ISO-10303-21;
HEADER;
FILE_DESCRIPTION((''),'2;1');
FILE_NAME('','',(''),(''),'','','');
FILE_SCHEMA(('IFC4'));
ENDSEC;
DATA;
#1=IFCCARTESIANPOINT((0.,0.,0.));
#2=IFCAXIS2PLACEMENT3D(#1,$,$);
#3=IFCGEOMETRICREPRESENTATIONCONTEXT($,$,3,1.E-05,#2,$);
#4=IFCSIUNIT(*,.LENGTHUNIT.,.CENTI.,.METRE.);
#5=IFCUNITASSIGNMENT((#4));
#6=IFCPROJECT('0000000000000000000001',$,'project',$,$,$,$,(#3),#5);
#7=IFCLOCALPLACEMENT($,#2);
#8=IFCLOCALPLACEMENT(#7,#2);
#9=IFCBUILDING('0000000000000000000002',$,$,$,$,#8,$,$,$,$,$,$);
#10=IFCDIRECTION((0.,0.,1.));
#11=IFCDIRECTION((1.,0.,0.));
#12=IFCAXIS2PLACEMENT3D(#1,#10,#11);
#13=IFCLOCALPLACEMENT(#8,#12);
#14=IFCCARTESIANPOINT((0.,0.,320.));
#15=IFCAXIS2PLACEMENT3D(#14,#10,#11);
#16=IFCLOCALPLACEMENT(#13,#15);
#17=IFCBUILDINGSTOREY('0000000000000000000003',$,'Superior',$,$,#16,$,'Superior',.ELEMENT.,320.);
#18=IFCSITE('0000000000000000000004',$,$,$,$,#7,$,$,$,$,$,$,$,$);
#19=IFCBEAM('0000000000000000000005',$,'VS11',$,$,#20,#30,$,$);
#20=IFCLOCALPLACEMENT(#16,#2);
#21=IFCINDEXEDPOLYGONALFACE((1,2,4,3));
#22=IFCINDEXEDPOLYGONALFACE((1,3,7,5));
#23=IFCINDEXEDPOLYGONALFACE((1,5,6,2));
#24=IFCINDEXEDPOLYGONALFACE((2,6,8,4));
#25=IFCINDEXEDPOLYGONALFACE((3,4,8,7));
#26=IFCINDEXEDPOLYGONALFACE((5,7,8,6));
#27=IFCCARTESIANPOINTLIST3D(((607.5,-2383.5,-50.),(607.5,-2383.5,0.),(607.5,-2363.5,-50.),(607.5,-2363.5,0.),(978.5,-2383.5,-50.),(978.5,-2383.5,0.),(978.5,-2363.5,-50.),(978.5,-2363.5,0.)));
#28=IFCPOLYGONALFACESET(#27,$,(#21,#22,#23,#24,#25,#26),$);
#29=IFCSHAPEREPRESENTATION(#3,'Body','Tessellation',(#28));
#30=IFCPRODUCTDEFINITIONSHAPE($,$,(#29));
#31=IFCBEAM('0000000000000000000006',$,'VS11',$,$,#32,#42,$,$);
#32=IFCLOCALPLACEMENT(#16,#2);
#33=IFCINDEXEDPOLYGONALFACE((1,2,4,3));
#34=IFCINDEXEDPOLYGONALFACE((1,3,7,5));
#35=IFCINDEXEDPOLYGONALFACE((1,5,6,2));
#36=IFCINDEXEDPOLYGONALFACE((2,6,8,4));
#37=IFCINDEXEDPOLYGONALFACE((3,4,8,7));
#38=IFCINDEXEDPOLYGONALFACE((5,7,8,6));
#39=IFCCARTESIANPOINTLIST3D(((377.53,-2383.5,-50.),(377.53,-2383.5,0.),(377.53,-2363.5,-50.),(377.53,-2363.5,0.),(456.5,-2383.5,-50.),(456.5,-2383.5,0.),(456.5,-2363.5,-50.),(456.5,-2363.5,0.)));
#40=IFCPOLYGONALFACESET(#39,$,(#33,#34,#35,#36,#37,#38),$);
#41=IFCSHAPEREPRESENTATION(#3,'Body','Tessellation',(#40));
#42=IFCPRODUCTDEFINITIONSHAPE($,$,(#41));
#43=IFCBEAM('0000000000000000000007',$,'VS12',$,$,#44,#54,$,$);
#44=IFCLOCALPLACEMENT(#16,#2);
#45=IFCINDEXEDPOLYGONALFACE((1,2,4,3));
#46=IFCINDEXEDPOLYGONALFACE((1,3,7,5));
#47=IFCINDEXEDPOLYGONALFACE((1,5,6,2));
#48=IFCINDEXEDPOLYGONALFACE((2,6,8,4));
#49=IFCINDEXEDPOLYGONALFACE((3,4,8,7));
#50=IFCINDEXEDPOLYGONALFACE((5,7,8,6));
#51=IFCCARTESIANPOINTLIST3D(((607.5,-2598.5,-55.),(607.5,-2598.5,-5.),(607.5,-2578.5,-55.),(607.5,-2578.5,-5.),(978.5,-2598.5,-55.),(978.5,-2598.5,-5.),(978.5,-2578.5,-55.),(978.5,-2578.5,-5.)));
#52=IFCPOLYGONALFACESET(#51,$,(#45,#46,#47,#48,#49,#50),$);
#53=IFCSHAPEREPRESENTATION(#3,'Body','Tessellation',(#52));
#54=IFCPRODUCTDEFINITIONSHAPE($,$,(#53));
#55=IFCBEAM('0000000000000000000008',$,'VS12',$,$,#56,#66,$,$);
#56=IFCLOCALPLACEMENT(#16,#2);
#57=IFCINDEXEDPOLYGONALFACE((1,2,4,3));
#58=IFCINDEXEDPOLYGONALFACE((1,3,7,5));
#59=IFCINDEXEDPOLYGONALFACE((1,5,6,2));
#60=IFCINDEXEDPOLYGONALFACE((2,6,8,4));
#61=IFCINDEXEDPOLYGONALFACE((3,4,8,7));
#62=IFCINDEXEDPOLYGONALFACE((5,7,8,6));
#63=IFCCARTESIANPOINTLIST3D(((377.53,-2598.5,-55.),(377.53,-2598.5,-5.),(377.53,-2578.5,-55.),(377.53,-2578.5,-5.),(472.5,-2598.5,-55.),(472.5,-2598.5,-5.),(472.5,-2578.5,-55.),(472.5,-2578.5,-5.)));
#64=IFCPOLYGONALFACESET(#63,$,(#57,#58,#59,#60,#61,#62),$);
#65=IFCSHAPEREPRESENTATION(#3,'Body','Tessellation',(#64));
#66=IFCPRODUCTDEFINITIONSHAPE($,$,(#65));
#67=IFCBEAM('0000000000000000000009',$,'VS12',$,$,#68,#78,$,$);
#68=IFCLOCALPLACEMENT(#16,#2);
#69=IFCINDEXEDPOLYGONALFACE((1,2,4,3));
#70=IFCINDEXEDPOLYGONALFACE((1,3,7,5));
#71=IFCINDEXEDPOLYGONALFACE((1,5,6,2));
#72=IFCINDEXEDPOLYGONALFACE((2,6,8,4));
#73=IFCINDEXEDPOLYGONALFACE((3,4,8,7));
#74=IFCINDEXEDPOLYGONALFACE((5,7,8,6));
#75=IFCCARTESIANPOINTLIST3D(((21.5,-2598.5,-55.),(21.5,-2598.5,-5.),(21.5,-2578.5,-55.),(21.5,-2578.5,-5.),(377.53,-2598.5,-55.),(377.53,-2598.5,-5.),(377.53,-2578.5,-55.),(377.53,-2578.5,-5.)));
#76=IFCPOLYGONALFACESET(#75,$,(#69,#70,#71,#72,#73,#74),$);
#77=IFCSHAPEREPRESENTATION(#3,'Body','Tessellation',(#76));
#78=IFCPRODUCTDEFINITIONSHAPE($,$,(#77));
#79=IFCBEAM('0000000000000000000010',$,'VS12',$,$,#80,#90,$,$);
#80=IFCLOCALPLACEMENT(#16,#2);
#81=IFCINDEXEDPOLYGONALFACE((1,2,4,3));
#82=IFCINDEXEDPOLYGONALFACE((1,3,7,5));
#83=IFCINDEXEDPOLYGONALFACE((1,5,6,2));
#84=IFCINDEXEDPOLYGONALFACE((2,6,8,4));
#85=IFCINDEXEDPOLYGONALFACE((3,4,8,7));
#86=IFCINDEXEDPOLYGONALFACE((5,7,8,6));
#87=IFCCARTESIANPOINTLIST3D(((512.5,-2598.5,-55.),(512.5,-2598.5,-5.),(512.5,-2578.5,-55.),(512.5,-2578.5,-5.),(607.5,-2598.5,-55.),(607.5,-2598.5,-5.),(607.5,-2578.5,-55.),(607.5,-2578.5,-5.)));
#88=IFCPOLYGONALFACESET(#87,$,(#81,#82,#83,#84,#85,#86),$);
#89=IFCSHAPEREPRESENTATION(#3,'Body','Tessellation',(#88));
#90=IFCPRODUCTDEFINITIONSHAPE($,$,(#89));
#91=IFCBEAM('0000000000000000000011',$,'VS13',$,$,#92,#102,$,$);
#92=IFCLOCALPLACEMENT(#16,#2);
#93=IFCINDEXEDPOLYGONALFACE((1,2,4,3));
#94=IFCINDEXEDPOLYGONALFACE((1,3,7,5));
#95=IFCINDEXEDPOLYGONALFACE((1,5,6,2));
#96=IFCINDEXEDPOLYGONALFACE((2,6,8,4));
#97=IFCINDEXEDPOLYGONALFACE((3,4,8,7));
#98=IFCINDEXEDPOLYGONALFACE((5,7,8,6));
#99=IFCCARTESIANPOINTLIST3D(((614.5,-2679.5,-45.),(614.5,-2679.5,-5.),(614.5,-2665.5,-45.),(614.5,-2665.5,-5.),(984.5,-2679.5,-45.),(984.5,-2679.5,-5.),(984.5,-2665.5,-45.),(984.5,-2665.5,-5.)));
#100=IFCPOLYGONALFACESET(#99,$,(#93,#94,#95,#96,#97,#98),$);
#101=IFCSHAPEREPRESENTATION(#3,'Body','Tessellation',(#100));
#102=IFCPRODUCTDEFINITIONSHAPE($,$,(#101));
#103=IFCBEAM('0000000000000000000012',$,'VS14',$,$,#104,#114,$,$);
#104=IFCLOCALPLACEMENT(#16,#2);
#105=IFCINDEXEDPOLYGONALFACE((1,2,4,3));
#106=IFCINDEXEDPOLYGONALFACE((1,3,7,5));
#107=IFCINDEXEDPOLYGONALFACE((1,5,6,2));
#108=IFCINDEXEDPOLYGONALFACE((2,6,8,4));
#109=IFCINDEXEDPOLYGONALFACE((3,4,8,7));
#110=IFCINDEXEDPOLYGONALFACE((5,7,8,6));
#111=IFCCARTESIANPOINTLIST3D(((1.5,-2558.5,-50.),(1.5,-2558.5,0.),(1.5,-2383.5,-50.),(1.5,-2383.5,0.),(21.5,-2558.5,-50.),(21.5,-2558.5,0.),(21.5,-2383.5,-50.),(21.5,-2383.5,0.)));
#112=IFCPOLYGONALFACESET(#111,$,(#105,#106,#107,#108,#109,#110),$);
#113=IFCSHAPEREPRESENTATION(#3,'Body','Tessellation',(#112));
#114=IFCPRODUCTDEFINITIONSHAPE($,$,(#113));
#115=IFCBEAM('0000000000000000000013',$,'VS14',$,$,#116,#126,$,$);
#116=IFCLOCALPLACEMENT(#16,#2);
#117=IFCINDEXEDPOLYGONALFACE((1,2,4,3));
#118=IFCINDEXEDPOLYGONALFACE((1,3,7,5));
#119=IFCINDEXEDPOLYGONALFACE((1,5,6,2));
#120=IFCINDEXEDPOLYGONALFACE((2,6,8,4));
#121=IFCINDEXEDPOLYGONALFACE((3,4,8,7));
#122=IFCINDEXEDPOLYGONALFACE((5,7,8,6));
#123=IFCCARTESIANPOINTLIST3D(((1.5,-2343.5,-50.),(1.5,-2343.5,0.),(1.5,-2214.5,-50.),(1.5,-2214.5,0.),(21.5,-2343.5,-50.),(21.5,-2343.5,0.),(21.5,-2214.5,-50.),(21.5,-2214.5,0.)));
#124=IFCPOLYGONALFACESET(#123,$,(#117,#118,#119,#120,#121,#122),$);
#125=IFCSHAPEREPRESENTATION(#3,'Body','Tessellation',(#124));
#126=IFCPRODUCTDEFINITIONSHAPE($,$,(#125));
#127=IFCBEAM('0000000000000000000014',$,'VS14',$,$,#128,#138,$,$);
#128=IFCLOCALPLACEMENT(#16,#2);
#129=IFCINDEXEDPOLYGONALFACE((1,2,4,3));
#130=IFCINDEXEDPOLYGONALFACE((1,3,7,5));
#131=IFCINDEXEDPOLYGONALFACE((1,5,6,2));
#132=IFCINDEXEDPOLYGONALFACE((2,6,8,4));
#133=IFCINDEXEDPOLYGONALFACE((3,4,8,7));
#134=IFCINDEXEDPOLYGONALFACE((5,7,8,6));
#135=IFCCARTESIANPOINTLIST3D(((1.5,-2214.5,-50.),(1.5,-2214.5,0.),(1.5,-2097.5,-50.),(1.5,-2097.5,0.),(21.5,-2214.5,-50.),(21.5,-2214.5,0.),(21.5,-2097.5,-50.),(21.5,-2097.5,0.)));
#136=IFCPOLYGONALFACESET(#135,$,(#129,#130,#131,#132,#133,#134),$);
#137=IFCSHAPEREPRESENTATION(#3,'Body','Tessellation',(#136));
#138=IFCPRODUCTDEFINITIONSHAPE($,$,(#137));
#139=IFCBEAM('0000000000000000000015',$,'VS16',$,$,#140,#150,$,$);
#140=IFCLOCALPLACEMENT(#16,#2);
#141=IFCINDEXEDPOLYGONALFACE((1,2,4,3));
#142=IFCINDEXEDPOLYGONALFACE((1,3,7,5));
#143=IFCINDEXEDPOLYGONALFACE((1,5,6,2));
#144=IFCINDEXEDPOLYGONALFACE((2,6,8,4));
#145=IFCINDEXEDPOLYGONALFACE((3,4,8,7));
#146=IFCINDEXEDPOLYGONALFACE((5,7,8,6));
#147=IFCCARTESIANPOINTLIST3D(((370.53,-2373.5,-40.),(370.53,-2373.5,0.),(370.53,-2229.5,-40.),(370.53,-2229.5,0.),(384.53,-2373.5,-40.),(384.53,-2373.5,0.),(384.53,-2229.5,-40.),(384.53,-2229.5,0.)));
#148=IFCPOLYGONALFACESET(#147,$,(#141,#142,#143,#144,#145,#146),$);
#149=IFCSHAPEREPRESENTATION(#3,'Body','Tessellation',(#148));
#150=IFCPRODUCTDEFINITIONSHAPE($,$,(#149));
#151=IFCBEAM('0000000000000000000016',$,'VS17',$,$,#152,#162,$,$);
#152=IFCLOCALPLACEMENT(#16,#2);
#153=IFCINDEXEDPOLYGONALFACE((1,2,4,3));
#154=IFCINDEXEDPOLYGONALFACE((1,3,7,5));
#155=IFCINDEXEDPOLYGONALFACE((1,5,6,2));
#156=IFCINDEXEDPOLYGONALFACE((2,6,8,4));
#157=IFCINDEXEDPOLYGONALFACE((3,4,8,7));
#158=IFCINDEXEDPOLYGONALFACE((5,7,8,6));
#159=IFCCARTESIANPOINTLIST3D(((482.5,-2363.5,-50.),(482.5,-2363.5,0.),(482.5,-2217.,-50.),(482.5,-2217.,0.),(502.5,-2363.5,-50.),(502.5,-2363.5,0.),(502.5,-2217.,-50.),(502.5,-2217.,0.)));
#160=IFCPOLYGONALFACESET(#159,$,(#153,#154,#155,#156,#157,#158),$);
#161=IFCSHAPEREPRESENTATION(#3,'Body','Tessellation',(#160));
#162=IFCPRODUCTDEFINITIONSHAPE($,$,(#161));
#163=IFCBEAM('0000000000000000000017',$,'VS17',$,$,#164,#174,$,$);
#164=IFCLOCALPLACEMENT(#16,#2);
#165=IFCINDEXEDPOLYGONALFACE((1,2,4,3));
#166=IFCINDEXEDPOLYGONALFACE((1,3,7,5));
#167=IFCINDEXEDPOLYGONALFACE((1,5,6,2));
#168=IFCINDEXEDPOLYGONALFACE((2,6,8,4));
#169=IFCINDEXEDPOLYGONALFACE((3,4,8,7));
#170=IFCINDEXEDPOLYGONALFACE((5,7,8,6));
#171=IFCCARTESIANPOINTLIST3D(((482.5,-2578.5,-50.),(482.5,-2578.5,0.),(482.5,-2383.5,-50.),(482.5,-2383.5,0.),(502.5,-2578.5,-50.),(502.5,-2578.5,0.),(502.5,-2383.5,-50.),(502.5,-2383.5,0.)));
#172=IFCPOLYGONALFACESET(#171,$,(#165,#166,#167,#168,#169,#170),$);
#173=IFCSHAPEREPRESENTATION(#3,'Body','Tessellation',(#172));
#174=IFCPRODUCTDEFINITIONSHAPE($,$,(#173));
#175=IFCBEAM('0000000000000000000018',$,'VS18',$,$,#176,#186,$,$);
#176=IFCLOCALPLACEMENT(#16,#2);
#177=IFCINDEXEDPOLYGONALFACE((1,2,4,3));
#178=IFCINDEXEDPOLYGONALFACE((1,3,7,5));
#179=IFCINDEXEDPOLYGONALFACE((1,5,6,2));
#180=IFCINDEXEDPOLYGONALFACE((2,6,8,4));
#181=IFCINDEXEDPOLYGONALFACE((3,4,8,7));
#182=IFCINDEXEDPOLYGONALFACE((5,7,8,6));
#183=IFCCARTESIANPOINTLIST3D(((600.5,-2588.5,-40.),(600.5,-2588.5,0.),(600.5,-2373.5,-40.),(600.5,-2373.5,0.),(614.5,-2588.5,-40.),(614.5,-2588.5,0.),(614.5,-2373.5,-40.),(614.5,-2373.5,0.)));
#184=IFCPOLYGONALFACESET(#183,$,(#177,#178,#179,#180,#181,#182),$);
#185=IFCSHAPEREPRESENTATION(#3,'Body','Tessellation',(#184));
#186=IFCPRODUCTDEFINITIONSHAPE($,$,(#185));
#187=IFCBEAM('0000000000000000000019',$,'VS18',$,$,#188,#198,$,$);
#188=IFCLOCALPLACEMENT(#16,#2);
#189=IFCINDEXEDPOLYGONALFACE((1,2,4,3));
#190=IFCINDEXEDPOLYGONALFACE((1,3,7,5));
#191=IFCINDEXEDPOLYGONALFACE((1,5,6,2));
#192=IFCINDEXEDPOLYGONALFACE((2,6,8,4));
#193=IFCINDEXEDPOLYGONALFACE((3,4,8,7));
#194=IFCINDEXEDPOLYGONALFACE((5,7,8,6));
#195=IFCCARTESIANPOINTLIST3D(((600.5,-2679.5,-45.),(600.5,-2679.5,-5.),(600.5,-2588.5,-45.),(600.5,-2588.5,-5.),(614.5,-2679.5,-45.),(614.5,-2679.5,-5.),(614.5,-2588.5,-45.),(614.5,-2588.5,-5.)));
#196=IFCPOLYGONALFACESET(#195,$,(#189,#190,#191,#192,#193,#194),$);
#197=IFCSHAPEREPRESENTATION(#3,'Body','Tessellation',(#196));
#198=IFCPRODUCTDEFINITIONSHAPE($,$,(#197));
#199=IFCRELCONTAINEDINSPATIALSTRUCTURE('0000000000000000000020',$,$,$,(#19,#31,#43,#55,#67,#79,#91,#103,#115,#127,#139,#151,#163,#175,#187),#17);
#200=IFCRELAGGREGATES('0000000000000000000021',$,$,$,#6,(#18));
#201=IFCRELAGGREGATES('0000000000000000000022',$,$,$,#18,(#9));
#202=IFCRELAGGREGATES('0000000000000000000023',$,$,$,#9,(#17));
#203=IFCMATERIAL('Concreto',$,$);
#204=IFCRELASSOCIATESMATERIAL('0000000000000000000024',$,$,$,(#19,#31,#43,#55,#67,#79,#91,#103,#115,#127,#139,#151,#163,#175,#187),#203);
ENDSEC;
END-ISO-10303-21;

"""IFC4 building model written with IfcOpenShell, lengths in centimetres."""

from ifc_helpers import new_model, si_unit, frame, origin, origin_with_axes, place, context, project, spatial, polyline, outline, extrude, material, element, save


model = new_model("IFC4")

# Units and contexts
context_of_model = context(None, 3, precision=1e-05, world=origin())
ifc_project = project(units=[si_unit("LENGTHUNIT", "METRE", prefix="CENTI")], contexts=[context_of_model])

# Site, building, storey
site_placement = place(None, origin())
site = spatial("IfcSite", under=ifc_project, at=site_placement)
building_placement = place(site_placement, origin())
building = spatial("IfcBuilding", under=site, at=building_placement)
placement = place(building_placement, origin_with_axes())
storey_placement = place(placement, frame((0.0, 0.0, 320.0), z_axis=(0.0, 0.0, 1.0), x_axis=(1.0, 0.0, 0.0)))
storey = spatial("IfcBuildingStorey", under=building, at=storey_placement, Name="Superior", LongName="Superior", CompositionType="ELEMENT", Elevation=320.0)

# Shared definitions
ifc_material = material(Name="Concreto")

# Beams
beam_1_placement = place(storey_placement, frame((793.0, -2373.5, 0.0), z_axis=(0.0, 0.0, 1.0), x_axis=(1.0, 0.0, 0.0)))
element("IfcBeam", 1, at=beam_1_placement, inside=storey, material=ifc_material, Name="VS11", context=context_of_model, shape_type="SolidModel", body=[
    extrude(outline(polyline([(-10.0, -25.0), (10.0, -25.0), (10.0, 25.0), (-10.0, 25.0), (-10.0, -25.0)])), frame((-185.5, 0.0, -25.0), z_axis=(1.0, 0.0, 0.0), x_axis=(0.0, -1.0, 0.0)), (0.0, 0.0, 1.0), 371.0),
])
beam_2_placement = place(storey_placement, frame((417.01, -2373.5, 0.0), z_axis=(0.0, 0.0, 1.0), x_axis=(1.0, 0.0, 0.0)))
element("IfcBeam", 2, at=beam_2_placement, inside=storey, material=ifc_material, Name="VS11", context=context_of_model, shape_type="SolidModel", body=[
    extrude(outline(polyline([(-10.0, -25.0), (10.0, -25.0), (10.0, 25.0), (-10.0, 25.0), (-10.0, -25.0)])), frame((-39.48, 0.0, -25.0), z_axis=(1.0, 0.0, 0.0), x_axis=(0.0, -1.0, 0.0)), (0.0, 0.0, 1.0), 78.97),
])
beam_3_placement = place(storey_placement, frame((793.0, -2588.5, -5.0), z_axis=(0.0, 0.0, 1.0), x_axis=(1.0, 0.0, 0.0)))
element("IfcBeam", 3, at=beam_3_placement, inside=storey, material=ifc_material, Name="VS12", context=context_of_model, shape_type="SolidModel", body=[
    extrude(outline(polyline([(-10.0, -25.0), (10.0, -25.0), (10.0, 25.0), (-10.0, 25.0), (-10.0, -25.0)])), frame((-185.5, 0.0, -25.0), z_axis=(1.0, 0.0, 0.0), x_axis=(0.0, -1.0, 0.0)), (0.0, 0.0, 1.0), 371.0),
])
beam_4_placement = place(storey_placement, frame((425.01, -2588.5, -5.0), z_axis=(0.0, 0.0, 1.0), x_axis=(1.0, 0.0, 0.0)))
element("IfcBeam", 4, at=beam_4_placement, inside=storey, material=ifc_material, Name="VS12", context=context_of_model, shape_type="SolidModel", body=[
    extrude(outline(polyline([(-10.0, -25.0), (10.0, -25.0), (10.0, 25.0), (-10.0, 25.0), (-10.0, -25.0)])), frame((-47.48, 0.0, -25.0), z_axis=(1.0, 0.0, 0.0), x_axis=(0.0, -1.0, 0.0)), (0.0, 0.0, 1.0), 94.97),
])
beam_5_placement = place(storey_placement, frame((199.51, -2588.5, -5.0), z_axis=(0.0, 0.0, 1.0), x_axis=(1.0, 0.0, 0.0)))
element("IfcBeam", 5, at=beam_5_placement, inside=storey, material=ifc_material, Name="VS12", context=context_of_model, shape_type="SolidModel", body=[
    extrude(outline(polyline([(-10.0, -25.0), (10.0, -25.0), (10.0, 25.0), (-10.0, 25.0), (-10.0, -25.0)])), frame((-178.01, 0.0, -25.0), z_axis=(1.0, 0.0, 0.0), x_axis=(0.0, -1.0, 0.0)), (0.0, 0.0, 1.0), 356.03),
])
beam_6_placement = place(storey_placement, frame((560.0, -2588.5, -5.0), z_axis=(0.0, 0.0, 1.0), x_axis=(1.0, 0.0, 0.0)))
element("IfcBeam", 6, at=beam_6_placement, inside=storey, material=ifc_material, Name="VS12", context=context_of_model, shape_type="SolidModel", body=[
    extrude(outline(polyline([(-10.0, -25.0), (10.0, -25.0), (10.0, 25.0), (-10.0, 25.0), (-10.0, -25.0)])), frame((-47.5, 0.0, -25.0), z_axis=(1.0, 0.0, 0.0), x_axis=(0.0, -1.0, 0.0)), (0.0, 0.0, 1.0), 95.0),
])
beam_7_placement = place(storey_placement, frame((799.5, -2672.5, -5.0), z_axis=(0.0, 0.0, 1.0), x_axis=(1.0, 0.0, 0.0)))
element("IfcBeam", 7, at=beam_7_placement, inside=storey, material=ifc_material, Name="VS13", context=context_of_model, shape_type="SolidModel", body=[
    extrude(outline(polyline([(-7.0, -20.0), (7.0, -20.0), (7.0, 20.0), (-7.0, 20.0), (-7.0, -20.0)])), frame((-185.0, 0.0, -20.0), z_axis=(1.0, 0.0, 0.0), x_axis=(0.0, -1.0, 0.0)), (0.0, 0.0, 1.0), 370.0),
])
beam_8_placement = place(storey_placement, frame((11.5, -2471.0, 0.0), z_axis=(0.0, 0.0, 1.0), x_axis=(1.0, 0.0, 0.0)))
element("IfcBeam", 8, at=beam_8_placement, inside=storey, material=ifc_material, Name="VS14", context=context_of_model, shape_type="SolidModel", body=[
    extrude(outline(polyline([(-10.0, -25.0), (10.0, -25.0), (10.0, 25.0), (-10.0, 25.0), (-10.0, -25.0)])), frame((0.0, -87.5, -25.0), z_axis=(0.0, 1.0, 0.0), x_axis=(1.0, 0.0, 0.0)), (0.0, 0.0, 1.0), 175.0),
])
beam_9_placement = place(storey_placement, frame((11.5, -2279.0, 0.0), z_axis=(0.0, 0.0, 1.0), x_axis=(1.0, 0.0, 0.0)))
element("IfcBeam", 9, at=beam_9_placement, inside=storey, material=ifc_material, Name="VS14", context=context_of_model, shape_type="SolidModel", body=[
    extrude(outline(polyline([(-10.0, -25.0), (10.0, -25.0), (10.0, 25.0), (-10.0, 25.0), (-10.0, -25.0)])), frame((0.0, -64.5, -25.0), z_axis=(0.0, 1.0, 0.0), x_axis=(1.0, 0.0, 0.0)), (0.0, 0.0, 1.0), 129.0),
])
beam_10_placement = place(storey_placement, frame((11.5, -2156.0, 0.0), z_axis=(0.0, 0.0, 1.0), x_axis=(1.0, 0.0, 0.0)))
element("IfcBeam", 10, at=beam_10_placement, inside=storey, material=ifc_material, Name="VS14", context=context_of_model, shape_type="SolidModel", body=[
    extrude(outline(polyline([(-10.0, -25.0), (10.0, -25.0), (10.0, 25.0), (-10.0, 25.0), (-10.0, -25.0)])), frame((0.0, -58.5, -25.0), z_axis=(0.0, 1.0, 0.0), x_axis=(1.0, 0.0, 0.0)), (0.0, 0.0, 1.0), 117.0),
])
beam_11_placement = place(storey_placement, frame((377.53, -2301.5, 0.0), z_axis=(0.0, 0.0, 1.0), x_axis=(1.0, 0.0, 0.0)))
element("IfcBeam", 11, at=beam_11_placement, inside=storey, material=ifc_material, Name="VS16", context=context_of_model, shape_type="SolidModel", body=[
    extrude(outline(polyline([(-7.0, -20.0), (7.0, -20.0), (7.0, 20.0), (-7.0, 20.0), (-7.0, -20.0)])), frame((0.0, -72.0, -20.0), z_axis=(0.0, 1.0, 0.0), x_axis=(1.0, 0.0, 0.0)), (0.0, 0.0, 1.0), 144.0),
])
beam_12_placement = place(storey_placement, frame((492.5, -2290.25, 0.0), z_axis=(0.0, 0.0, 1.0), x_axis=(1.0, 0.0, 0.0)))
element("IfcBeam", 12, at=beam_12_placement, inside=storey, material=ifc_material, Name="VS17", context=context_of_model, shape_type="SolidModel", body=[
    extrude(outline(polyline([(-10.0, -25.0), (10.0, -25.0), (10.0, 25.0), (-10.0, 25.0), (-10.0, -25.0)])), frame((0.0, -73.25, -25.0), z_axis=(0.0, 1.0, 0.0), x_axis=(1.0, 0.0, 0.0)), (0.0, 0.0, 1.0), 146.5),
])
beam_13_placement = place(storey_placement, frame((492.5, -2481.0, 0.0), z_axis=(0.0, 0.0, 1.0), x_axis=(1.0, 0.0, 0.0)))
element("IfcBeam", 13, at=beam_13_placement, inside=storey, material=ifc_material, Name="VS17", context=context_of_model, shape_type="SolidModel", body=[
    extrude(outline(polyline([(-10.0, -25.0), (10.0, -25.0), (10.0, 25.0), (-10.0, 25.0), (-10.0, -25.0)])), frame((0.0, -97.5, -25.0), z_axis=(0.0, 1.0, 0.0), x_axis=(1.0, 0.0, 0.0)), (0.0, 0.0, 1.0), 195.0),
])
beam_14_placement = place(storey_placement, frame((607.5, -2481.0, 0.0), z_axis=(0.0, 0.0, 1.0), x_axis=(1.0, 0.0, 0.0)))
element("IfcBeam", 14, at=beam_14_placement, inside=storey, material=ifc_material, Name="VS18", context=context_of_model, shape_type="SolidModel", body=[
    extrude(outline(polyline([(-7.0, -20.0), (7.0, -20.0), (7.0, 20.0), (-7.0, 20.0), (-7.0, -20.0)])), frame((0.0, -107.5, -20.0), z_axis=(0.0, 1.0, 0.0), x_axis=(1.0, 0.0, 0.0)), (0.0, 0.0, 1.0), 215.0),
])
beam_15_placement = place(storey_placement, frame((607.5, -2634.0, -5.0), z_axis=(0.0, 0.0, 1.0), x_axis=(1.0, 0.0, 0.0)))
element("IfcBeam", 15, at=beam_15_placement, inside=storey, material=ifc_material, Name="VS18", context=context_of_model, shape_type="SolidModel", body=[
    extrude(outline(polyline([(-7.0, -20.0), (7.0, -20.0), (7.0, 20.0), (-7.0, 20.0), (-7.0, -20.0)])), frame((0.0, -45.5, -20.0), z_axis=(0.0, 1.0, 0.0), x_axis=(1.0, 0.0, 0.0)), (0.0, 0.0, 1.0), 91.0),
])

save(model, "model.ifc")
